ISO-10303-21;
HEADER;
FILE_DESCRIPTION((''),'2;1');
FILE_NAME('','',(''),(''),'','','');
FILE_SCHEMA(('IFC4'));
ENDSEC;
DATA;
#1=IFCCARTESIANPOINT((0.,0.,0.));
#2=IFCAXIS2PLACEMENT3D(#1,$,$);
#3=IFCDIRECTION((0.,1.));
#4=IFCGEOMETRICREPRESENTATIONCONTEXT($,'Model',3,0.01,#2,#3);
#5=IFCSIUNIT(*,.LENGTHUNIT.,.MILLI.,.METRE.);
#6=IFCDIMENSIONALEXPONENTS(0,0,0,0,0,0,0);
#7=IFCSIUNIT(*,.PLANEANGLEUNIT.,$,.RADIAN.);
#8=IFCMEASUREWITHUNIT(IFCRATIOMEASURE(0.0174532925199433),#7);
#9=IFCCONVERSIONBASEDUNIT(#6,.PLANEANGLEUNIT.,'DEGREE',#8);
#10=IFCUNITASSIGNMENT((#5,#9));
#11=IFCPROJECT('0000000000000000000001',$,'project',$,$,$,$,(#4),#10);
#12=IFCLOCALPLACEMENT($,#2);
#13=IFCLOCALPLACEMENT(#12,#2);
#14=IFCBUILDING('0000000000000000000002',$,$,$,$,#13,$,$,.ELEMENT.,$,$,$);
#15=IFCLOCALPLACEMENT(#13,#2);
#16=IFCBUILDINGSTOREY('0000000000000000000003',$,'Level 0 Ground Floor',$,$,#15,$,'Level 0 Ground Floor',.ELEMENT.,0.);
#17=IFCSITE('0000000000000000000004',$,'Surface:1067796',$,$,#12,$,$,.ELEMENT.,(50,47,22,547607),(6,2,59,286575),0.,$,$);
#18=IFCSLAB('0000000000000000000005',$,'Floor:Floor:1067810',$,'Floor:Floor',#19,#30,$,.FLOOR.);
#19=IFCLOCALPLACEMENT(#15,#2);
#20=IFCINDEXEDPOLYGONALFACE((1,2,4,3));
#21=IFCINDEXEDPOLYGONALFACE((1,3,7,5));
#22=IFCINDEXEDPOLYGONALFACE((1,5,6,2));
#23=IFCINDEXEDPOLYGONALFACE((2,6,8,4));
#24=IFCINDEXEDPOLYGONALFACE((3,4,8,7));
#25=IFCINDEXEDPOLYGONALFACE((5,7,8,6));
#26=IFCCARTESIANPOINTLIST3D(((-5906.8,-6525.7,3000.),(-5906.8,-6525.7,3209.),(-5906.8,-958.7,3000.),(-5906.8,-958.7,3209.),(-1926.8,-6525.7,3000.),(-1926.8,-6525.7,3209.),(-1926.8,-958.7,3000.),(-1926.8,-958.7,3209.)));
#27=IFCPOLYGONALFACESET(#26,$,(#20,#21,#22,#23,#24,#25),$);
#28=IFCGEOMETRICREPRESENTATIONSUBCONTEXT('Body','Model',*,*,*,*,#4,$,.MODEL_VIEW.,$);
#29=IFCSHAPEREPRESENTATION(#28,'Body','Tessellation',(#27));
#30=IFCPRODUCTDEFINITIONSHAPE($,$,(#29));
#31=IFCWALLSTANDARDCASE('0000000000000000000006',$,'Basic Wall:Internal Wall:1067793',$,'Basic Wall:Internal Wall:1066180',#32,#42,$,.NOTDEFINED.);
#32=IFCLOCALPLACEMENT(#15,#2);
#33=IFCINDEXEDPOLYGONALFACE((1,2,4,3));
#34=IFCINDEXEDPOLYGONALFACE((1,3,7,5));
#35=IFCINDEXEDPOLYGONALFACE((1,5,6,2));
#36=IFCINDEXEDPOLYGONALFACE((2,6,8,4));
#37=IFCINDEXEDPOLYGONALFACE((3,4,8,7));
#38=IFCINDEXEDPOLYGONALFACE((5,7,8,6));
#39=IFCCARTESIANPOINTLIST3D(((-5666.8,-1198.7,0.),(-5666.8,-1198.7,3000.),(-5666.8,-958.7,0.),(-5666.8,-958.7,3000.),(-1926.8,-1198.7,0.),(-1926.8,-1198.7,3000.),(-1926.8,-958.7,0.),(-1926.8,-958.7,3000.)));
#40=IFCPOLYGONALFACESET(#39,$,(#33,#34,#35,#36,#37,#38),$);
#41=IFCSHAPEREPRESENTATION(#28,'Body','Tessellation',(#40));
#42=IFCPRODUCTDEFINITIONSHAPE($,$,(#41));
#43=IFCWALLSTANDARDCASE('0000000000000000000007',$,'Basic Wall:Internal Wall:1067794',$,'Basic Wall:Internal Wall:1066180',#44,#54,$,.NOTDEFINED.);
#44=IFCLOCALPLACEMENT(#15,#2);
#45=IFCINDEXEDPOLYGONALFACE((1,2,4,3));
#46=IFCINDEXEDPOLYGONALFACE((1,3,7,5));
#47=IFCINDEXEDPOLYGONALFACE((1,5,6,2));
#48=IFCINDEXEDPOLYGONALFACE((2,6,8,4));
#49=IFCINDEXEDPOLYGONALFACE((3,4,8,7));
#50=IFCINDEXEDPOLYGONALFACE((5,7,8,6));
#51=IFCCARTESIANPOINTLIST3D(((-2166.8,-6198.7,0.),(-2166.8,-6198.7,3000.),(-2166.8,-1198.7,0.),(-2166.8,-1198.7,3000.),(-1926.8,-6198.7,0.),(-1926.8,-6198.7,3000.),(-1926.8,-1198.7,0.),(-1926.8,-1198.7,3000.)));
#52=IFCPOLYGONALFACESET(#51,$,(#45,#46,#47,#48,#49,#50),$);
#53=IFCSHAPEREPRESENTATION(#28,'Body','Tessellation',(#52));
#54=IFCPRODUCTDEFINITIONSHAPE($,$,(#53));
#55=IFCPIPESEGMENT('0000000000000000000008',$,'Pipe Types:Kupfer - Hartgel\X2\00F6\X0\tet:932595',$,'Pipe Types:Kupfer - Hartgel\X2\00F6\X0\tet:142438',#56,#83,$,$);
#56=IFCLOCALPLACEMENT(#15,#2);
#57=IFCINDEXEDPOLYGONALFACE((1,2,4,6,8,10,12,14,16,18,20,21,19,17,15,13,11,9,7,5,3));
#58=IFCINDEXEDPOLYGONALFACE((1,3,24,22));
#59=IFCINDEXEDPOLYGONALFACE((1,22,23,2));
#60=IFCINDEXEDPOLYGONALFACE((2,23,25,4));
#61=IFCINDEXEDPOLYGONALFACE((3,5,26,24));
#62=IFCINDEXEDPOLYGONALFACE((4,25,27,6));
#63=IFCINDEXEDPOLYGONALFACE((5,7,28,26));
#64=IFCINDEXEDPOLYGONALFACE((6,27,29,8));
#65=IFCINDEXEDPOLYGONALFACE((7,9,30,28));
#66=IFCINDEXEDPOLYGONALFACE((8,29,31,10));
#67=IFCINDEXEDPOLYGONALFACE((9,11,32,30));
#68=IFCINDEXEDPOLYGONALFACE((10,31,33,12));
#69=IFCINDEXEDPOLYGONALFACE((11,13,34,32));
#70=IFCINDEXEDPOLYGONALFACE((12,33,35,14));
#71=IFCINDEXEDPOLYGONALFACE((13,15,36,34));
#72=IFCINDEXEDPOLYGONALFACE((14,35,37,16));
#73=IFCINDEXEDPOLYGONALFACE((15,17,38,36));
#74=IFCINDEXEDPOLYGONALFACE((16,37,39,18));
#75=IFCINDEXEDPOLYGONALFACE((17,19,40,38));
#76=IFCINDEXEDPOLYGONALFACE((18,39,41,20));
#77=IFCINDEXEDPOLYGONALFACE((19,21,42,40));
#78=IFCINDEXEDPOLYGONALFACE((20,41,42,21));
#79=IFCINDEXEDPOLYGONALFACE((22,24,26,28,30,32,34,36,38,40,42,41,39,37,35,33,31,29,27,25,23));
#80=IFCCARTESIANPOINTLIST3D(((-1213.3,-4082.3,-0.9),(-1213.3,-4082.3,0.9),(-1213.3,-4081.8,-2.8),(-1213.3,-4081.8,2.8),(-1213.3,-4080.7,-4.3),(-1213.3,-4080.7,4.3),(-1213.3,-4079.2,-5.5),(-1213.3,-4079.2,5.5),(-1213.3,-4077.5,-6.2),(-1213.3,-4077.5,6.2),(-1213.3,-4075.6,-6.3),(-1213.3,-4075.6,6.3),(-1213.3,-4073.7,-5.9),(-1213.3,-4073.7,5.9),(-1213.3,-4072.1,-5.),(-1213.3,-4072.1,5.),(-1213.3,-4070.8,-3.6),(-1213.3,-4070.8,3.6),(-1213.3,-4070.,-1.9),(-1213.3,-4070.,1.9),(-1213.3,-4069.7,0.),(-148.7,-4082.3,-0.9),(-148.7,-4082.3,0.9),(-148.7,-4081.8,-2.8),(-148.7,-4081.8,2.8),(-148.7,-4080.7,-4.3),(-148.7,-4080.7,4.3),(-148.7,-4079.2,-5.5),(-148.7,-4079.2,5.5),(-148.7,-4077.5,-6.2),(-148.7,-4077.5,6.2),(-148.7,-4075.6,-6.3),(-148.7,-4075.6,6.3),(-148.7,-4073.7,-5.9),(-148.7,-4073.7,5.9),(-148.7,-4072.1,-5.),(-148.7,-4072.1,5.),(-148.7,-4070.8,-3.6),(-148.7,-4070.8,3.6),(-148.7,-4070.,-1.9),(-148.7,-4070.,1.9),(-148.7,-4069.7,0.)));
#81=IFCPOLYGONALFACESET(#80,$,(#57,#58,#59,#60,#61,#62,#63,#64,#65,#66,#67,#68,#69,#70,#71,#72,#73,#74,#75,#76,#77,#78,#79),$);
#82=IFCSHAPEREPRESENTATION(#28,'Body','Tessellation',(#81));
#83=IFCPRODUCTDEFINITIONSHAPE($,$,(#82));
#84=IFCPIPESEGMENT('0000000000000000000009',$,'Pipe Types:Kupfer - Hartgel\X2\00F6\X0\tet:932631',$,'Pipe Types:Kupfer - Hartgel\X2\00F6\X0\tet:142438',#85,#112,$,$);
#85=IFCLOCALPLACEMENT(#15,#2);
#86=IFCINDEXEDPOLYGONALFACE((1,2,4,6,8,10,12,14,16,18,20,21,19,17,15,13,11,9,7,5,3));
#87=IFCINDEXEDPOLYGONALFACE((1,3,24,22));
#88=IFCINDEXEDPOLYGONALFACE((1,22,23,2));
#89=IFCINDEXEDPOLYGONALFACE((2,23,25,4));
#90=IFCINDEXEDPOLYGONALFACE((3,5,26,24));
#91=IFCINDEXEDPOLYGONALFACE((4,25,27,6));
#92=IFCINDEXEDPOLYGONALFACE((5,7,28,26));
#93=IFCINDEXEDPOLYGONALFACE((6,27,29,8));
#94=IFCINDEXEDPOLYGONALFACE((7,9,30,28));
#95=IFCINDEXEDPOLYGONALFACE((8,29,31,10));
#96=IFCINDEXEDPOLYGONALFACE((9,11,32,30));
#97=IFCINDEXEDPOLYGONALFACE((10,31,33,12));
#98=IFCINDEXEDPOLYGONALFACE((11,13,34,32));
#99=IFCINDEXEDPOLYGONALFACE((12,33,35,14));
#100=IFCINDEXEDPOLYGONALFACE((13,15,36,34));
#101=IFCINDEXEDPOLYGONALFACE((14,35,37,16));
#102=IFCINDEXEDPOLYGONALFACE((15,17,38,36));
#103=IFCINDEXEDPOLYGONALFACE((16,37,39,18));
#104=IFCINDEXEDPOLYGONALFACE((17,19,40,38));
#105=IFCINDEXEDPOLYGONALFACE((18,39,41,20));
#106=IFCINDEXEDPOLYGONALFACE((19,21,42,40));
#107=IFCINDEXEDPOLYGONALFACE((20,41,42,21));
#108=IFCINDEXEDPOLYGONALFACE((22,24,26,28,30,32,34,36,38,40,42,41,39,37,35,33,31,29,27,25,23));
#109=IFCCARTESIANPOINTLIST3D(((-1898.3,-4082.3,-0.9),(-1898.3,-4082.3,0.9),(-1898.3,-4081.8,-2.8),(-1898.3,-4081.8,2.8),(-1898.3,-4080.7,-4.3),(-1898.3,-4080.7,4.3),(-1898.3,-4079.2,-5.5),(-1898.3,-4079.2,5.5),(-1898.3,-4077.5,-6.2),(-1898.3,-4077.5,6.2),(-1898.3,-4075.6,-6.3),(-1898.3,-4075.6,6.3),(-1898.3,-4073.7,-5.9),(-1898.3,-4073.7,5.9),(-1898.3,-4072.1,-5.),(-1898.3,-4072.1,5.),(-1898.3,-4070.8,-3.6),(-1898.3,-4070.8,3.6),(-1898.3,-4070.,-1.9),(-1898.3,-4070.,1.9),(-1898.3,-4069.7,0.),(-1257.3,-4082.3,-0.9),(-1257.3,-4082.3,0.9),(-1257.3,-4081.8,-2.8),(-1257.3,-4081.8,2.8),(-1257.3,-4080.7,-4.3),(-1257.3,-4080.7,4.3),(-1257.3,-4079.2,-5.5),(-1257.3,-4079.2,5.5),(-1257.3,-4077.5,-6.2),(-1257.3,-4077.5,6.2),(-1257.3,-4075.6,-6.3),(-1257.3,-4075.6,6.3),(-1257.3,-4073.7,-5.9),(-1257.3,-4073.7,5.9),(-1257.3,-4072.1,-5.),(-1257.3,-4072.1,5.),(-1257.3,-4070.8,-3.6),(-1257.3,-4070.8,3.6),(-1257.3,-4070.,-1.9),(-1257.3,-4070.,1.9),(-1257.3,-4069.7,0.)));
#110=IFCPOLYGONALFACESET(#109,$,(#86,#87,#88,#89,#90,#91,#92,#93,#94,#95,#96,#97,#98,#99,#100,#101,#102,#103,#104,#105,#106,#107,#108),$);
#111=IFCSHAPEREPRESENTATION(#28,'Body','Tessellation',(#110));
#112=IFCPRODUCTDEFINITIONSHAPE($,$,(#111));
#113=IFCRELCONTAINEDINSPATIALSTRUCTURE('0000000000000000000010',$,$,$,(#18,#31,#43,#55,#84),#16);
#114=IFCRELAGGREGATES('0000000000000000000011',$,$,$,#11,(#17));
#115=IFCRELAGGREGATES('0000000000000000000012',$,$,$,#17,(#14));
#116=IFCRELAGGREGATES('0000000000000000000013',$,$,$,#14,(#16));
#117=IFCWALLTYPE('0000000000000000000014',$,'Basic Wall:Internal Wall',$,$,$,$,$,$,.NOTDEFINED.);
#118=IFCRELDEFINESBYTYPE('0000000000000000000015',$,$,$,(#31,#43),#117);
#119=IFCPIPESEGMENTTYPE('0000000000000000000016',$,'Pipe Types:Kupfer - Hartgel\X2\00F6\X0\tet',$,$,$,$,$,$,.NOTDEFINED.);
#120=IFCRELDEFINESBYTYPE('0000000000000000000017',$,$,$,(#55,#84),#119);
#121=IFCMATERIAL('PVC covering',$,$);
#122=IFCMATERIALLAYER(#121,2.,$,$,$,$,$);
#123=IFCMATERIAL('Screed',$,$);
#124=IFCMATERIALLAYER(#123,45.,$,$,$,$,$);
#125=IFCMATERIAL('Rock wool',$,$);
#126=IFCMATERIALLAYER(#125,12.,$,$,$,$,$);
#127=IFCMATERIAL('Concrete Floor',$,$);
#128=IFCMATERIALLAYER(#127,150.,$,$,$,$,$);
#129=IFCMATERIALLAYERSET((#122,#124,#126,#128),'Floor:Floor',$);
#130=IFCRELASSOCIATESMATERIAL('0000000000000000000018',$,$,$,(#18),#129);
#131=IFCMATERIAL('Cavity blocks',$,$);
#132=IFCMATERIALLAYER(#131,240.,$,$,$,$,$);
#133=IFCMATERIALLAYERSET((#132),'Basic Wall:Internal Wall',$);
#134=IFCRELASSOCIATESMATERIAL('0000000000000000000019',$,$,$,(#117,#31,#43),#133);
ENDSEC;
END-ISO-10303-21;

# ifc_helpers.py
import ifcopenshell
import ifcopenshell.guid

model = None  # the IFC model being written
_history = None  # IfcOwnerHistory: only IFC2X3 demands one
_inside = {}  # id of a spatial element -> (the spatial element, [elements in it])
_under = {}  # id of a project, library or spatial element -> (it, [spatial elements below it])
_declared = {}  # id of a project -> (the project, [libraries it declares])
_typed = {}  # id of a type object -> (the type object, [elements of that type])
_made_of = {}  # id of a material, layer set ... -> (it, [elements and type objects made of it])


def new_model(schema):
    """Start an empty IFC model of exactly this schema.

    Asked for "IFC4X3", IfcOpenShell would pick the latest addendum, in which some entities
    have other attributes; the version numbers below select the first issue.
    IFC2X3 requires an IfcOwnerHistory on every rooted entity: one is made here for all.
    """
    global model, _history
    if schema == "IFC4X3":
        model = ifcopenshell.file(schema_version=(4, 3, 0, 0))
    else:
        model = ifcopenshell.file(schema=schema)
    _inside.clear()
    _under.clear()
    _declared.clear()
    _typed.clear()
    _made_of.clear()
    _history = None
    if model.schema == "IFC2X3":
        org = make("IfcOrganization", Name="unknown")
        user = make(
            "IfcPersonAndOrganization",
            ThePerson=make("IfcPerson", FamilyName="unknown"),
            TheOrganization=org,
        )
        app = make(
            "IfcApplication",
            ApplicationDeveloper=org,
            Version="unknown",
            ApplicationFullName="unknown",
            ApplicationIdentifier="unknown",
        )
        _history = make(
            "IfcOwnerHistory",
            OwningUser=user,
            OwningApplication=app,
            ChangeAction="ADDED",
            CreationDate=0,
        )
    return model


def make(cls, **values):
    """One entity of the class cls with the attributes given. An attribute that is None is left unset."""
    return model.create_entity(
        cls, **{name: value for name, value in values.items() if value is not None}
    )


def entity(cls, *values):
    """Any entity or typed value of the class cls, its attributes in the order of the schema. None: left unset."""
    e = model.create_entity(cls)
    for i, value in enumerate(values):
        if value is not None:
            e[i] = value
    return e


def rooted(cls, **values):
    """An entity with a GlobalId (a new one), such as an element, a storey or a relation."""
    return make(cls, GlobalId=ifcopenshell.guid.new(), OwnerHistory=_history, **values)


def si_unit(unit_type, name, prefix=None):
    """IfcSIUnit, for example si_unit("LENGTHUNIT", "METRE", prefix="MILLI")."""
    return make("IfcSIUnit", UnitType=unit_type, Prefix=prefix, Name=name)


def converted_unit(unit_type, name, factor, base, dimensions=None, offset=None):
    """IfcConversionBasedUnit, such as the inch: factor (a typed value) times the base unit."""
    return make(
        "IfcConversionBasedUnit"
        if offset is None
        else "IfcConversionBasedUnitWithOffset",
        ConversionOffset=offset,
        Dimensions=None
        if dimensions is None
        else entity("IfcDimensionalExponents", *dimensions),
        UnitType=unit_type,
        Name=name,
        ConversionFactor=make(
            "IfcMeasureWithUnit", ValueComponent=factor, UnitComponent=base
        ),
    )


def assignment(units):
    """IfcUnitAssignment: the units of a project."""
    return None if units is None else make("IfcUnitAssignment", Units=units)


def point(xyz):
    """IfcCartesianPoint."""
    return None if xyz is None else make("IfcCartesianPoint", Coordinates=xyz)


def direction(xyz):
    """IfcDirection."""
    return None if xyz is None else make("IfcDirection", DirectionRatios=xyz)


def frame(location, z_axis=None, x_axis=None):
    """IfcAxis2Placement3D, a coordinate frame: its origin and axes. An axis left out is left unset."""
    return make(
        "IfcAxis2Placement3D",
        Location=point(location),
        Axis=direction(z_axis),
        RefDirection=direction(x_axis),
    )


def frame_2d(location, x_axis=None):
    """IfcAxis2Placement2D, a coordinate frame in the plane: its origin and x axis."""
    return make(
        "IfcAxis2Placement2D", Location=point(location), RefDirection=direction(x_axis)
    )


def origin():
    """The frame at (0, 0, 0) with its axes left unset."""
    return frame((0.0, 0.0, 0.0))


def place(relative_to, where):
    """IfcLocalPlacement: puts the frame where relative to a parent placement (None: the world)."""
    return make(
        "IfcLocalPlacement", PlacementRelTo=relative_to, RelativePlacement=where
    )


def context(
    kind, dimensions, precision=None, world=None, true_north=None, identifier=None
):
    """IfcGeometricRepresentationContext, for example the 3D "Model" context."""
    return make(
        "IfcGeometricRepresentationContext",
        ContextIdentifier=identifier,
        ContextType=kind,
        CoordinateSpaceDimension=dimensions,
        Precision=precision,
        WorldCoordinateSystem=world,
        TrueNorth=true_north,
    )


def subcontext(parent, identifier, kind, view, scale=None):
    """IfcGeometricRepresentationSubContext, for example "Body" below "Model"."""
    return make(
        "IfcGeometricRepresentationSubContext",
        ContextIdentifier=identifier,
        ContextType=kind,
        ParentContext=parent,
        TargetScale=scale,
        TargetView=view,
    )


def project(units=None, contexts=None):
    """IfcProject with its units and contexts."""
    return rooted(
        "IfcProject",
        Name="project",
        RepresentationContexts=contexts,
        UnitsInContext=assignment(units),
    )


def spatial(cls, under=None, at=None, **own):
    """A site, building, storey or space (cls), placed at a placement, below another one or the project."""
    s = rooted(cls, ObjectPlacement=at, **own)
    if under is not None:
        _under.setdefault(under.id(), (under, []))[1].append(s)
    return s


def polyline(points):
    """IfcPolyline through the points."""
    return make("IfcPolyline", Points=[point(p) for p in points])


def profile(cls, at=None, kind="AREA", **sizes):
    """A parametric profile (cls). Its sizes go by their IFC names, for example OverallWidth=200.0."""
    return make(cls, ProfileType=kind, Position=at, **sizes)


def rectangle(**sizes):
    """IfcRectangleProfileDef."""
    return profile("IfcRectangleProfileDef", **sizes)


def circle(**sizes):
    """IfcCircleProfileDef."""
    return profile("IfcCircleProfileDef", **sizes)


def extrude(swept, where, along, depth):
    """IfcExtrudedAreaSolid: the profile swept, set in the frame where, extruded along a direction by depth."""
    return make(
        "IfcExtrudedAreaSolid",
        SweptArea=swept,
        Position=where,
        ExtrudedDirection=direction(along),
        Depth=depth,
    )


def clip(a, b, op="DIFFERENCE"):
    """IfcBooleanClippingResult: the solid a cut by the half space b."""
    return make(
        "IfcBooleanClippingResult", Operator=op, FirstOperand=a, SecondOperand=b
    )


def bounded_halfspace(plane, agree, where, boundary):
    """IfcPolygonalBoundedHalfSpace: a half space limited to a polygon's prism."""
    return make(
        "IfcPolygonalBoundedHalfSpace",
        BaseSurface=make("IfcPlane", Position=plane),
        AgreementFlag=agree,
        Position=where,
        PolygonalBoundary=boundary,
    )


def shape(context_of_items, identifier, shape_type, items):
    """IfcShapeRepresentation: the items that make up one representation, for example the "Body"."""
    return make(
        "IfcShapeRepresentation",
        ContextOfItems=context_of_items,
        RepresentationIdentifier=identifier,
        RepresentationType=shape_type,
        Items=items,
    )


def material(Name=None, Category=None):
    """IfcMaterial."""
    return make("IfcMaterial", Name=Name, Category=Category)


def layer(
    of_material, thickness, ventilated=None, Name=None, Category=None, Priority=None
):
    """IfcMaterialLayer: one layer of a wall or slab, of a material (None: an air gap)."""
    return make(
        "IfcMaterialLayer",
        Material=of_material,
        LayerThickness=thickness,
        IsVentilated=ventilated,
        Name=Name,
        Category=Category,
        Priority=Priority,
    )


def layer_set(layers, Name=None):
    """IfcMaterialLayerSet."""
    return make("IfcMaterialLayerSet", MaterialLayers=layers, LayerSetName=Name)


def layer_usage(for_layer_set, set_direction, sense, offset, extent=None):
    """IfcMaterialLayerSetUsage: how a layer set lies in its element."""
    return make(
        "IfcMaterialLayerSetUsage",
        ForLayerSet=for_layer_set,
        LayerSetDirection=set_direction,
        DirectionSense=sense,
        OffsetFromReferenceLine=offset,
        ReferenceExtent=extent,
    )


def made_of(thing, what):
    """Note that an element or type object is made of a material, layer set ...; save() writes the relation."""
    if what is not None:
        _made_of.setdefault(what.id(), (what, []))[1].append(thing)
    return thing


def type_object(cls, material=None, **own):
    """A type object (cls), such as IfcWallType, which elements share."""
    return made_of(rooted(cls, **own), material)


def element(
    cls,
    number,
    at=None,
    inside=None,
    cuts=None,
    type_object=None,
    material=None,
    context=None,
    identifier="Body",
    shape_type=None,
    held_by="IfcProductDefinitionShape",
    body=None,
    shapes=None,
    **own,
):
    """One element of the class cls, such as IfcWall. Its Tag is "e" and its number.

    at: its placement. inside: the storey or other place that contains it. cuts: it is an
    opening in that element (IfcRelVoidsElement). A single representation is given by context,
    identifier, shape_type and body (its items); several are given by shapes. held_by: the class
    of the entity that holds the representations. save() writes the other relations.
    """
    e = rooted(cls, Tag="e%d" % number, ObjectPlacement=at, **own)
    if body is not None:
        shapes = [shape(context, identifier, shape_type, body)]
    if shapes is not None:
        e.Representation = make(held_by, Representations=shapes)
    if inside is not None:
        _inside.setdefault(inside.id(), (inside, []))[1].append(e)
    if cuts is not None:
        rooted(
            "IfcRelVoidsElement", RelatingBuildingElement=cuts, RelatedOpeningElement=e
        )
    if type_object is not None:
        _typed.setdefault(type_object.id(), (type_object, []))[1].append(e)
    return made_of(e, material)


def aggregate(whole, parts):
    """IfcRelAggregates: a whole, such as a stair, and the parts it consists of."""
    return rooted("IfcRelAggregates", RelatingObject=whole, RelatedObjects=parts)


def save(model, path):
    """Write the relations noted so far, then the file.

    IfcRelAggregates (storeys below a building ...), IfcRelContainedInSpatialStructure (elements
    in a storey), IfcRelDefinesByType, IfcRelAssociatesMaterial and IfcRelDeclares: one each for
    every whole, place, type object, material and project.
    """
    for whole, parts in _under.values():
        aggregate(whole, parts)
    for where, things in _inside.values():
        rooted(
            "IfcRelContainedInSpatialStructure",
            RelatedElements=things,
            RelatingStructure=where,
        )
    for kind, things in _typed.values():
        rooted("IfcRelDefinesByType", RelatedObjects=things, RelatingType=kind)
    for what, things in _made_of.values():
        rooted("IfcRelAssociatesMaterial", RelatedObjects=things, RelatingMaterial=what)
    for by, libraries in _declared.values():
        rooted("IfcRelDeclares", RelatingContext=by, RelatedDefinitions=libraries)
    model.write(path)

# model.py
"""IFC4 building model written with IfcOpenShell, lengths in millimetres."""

from ifc_helpers import new_model, entity, si_unit, converted_unit, direction, frame, frame_2d, origin, place, context, subcontext, project, spatial, polyline, rectangle, circle, extrude, clip, bounded_halfspace, material, layer, layer_set, layer_usage, type_object, element, save


model = new_model("IFC4")

# Units and contexts
model_context = context("Model", 3, precision=0.01, world=origin(), true_north=direction((0.0, 1.0)))
body_context = subcontext(model_context, "Body", "Model", "MODEL_VIEW")
ifc_project = project(units=[si_unit("LENGTHUNIT", "METRE", prefix="MILLI"), converted_unit("PLANEANGLEUNIT", "DEGREE", entity("IfcRatioMeasure", 0.0174532925199433), si_unit("PLANEANGLEUNIT", "RADIAN"), dimensions=[0, 0, 0, 0, 0, 0, 0])], contexts=[model_context])

# Site, building, storey
site_placement = place(None, origin())
site = spatial("IfcSite", under=ifc_project, at=site_placement, Name="Surface:1067796", CompositionType="ELEMENT", RefLatitude=(50, 47, 22, 547607), RefLongitude=(6, 2, 59, 286575), RefElevation=0.0)
building_placement = place(site_placement, origin())
building = spatial("IfcBuilding", under=site, at=building_placement, CompositionType="ELEMENT")
storey_placement = place(building_placement, origin())
storey = spatial("IfcBuildingStorey", under=building, at=storey_placement, Name="Level 0 Ground Floor", LongName="Level 0 Ground Floor", CompositionType="ELEMENT", Elevation=0.0)

# Slab
ifc_material_1 = material(Name="PVC covering")
ifc_layer_1 = layer(ifc_material_1, 2.0)
ifc_material_2 = material(Name="Screed")
ifc_layer_2 = layer(ifc_material_2, 45.0)
ifc_material_3 = material(Name="Rock wool")
ifc_layer_3 = layer(ifc_material_3, 12.0)
ifc_material_4 = material(Name="Concrete Floor")
ifc_layer_4 = layer(ifc_material_4, 150.0)
ifc_layer_set_1 = layer_set([ifc_layer_1, ifc_layer_2, ifc_layer_3, ifc_layer_4], Name="Floor:Floor")
ifc_layer_usage_1 = layer_usage(ifc_layer_set_1, "AXIS3", "POSITIVE", 0.0)
slab_placement = place(storey_placement, origin())
element("IfcSlab", 1, at=slab_placement, inside=storey, material=ifc_layer_usage_1, Name="Floor:Floor:1067810", ObjectType="Floor:Floor", PredefinedType="FLOOR", context=body_context, shape_type="SweptSolid", body=[
    extrude(rectangle(XDim=5567.0, YDim=3980.0, at=frame_2d((0.0, 0.0), x_axis=(1.0, 0.0))), frame((-3916.8, -3742.2, 3209.0), z_axis=(0.0, 0.0, -1.0), x_axis=(0.0, 1.0, 0.0)), (0.0, 0.0, 1.0), 209.0),
])

# Walls
ifc_material_5 = material(Name="Cavity blocks")
ifc_layer_5 = layer(ifc_material_5, 240.0)
ifc_layer_set_2 = layer_set([ifc_layer_5], Name="Basic Wall:Internal Wall")
ifc_layer_usage_2 = layer_usage(ifc_layer_set_2, "AXIS2", "NEGATIVE", 120.0)
wall_type = type_object("IfcWallType", Name="Basic Wall:Internal Wall", PredefinedType="NOTDEFINED", material=ifc_layer_set_2)
wall_1_placement = place(storey_placement, frame((-5666.8, -1078.7, 0.0)))
element("IfcWallStandardCase", 2, at=wall_1_placement, inside=storey, type_object=wall_type, material=ifc_layer_usage_2, Name="Basic Wall:Internal Wall:1067793", ObjectType="Basic Wall:Internal Wall:1066180", PredefinedType="NOTDEFINED", context=body_context, shape_type="Clipping", body=[
    clip(extrude(rectangle(XDim=3740.0, YDim=240.0, at=frame_2d((1870.0, 0.0), x_axis=(-1.0, 0.0))), origin(), (0.0, 0.0, 1.0), 3000.0), bounded_halfspace(frame((0.0, -120.0, 3000.0), z_axis=(0.0, 0.0, -1.0), x_axis=(0.0, -1.0, 0.0)), True, frame((0.0, -120.0, 3000.0)), polyline([(0.0, 0.0), (3500.0, 0.0), (3740.0, 0.0), (3740.0, 240.0), (0.0, 240.0), (0.0, 0.0)]))),
])
ifc_layer_usage_3 = layer_usage(ifc_layer_set_2, "AXIS2", "NEGATIVE", 120.0)
wall_2_placement = place(storey_placement, frame((-2046.8, -1198.7, 0.0), z_axis=(0.0, 0.0, 1.0), x_axis=(0.0, -1.0, 0.0)))
element("IfcWallStandardCase", 3, at=wall_2_placement, inside=storey, type_object=wall_type, material=ifc_layer_usage_3, Name="Basic Wall:Internal Wall:1067794", ObjectType="Basic Wall:Internal Wall:1066180", PredefinedType="NOTDEFINED", context=body_context, shape_type="Clipping", body=[
    clip(extrude(rectangle(XDim=5000.0, YDim=240.0, at=frame_2d((2500.0, 0.0), x_axis=(-1.0, 0.0))), origin(), (0.0, 0.0, 1.0), 3000.0), bounded_halfspace(frame((0.0, -120.0, 3000.0), z_axis=(0.0, 0.0, -1.0), x_axis=(1.0, 0.0, 0.0)), True, frame((0.0, -120.0, 3000.0)), polyline([(0.0, 0.0), (5000.0, 0.0), (5000.0, 240.0), (0.0, 240.0), (0.0, 0.0)]))),
])

# Pipe segments
pipe_segment_type_1 = type_object("IfcPipeSegmentType", Name="Pipe Types:Kupfer - Hartgelötet", PredefinedType="NOTDEFINED")
pipe_segment_1_placement = place(storey_placement, frame((-1213.3, -4084.0, -7.9)))
element("IfcPipeSegment", 4, at=pipe_segment_1_placement, inside=storey, type_object=pipe_segment_type_1, Name="Pipe Types:Kupfer - Hartgelötet:932595", ObjectType="Pipe Types:Kupfer - Hartgelötet:142438", context=body_context, shape_type="SweptSolid", body=[
    extrude(circle(Radius=6.3, at=frame_2d((0.0, 0.0), x_axis=(1.0, 0.0))), frame((0.0, 7.9, 7.9), z_axis=(1.0, 0.0, 0.0), x_axis=(0.0, 1.0, 0.0)), (0.0, 0.0, 1.0), 1064.6),
])
pipe_segment_2_placement = place(storey_placement, frame((-1898.3, -4084.0, -7.9)))
element("IfcPipeSegment", 5, at=pipe_segment_2_placement, inside=storey, type_object=pipe_segment_type_1, Name="Pipe Types:Kupfer - Hartgelötet:932631", ObjectType="Pipe Types:Kupfer - Hartgelötet:142438", context=body_context, shape_type="SweptSolid", body=[
    extrude(circle(Radius=6.3, at=frame_2d((0.0, 0.0), x_axis=(1.0, 0.0))), frame((0.0, 7.9, 7.9), z_axis=(1.0, 0.0, 0.0), x_axis=(0.0, 1.0, 0.0)), (0.0, 0.0, 1.0), 641.0),
])

save(model, "model.ifc")
